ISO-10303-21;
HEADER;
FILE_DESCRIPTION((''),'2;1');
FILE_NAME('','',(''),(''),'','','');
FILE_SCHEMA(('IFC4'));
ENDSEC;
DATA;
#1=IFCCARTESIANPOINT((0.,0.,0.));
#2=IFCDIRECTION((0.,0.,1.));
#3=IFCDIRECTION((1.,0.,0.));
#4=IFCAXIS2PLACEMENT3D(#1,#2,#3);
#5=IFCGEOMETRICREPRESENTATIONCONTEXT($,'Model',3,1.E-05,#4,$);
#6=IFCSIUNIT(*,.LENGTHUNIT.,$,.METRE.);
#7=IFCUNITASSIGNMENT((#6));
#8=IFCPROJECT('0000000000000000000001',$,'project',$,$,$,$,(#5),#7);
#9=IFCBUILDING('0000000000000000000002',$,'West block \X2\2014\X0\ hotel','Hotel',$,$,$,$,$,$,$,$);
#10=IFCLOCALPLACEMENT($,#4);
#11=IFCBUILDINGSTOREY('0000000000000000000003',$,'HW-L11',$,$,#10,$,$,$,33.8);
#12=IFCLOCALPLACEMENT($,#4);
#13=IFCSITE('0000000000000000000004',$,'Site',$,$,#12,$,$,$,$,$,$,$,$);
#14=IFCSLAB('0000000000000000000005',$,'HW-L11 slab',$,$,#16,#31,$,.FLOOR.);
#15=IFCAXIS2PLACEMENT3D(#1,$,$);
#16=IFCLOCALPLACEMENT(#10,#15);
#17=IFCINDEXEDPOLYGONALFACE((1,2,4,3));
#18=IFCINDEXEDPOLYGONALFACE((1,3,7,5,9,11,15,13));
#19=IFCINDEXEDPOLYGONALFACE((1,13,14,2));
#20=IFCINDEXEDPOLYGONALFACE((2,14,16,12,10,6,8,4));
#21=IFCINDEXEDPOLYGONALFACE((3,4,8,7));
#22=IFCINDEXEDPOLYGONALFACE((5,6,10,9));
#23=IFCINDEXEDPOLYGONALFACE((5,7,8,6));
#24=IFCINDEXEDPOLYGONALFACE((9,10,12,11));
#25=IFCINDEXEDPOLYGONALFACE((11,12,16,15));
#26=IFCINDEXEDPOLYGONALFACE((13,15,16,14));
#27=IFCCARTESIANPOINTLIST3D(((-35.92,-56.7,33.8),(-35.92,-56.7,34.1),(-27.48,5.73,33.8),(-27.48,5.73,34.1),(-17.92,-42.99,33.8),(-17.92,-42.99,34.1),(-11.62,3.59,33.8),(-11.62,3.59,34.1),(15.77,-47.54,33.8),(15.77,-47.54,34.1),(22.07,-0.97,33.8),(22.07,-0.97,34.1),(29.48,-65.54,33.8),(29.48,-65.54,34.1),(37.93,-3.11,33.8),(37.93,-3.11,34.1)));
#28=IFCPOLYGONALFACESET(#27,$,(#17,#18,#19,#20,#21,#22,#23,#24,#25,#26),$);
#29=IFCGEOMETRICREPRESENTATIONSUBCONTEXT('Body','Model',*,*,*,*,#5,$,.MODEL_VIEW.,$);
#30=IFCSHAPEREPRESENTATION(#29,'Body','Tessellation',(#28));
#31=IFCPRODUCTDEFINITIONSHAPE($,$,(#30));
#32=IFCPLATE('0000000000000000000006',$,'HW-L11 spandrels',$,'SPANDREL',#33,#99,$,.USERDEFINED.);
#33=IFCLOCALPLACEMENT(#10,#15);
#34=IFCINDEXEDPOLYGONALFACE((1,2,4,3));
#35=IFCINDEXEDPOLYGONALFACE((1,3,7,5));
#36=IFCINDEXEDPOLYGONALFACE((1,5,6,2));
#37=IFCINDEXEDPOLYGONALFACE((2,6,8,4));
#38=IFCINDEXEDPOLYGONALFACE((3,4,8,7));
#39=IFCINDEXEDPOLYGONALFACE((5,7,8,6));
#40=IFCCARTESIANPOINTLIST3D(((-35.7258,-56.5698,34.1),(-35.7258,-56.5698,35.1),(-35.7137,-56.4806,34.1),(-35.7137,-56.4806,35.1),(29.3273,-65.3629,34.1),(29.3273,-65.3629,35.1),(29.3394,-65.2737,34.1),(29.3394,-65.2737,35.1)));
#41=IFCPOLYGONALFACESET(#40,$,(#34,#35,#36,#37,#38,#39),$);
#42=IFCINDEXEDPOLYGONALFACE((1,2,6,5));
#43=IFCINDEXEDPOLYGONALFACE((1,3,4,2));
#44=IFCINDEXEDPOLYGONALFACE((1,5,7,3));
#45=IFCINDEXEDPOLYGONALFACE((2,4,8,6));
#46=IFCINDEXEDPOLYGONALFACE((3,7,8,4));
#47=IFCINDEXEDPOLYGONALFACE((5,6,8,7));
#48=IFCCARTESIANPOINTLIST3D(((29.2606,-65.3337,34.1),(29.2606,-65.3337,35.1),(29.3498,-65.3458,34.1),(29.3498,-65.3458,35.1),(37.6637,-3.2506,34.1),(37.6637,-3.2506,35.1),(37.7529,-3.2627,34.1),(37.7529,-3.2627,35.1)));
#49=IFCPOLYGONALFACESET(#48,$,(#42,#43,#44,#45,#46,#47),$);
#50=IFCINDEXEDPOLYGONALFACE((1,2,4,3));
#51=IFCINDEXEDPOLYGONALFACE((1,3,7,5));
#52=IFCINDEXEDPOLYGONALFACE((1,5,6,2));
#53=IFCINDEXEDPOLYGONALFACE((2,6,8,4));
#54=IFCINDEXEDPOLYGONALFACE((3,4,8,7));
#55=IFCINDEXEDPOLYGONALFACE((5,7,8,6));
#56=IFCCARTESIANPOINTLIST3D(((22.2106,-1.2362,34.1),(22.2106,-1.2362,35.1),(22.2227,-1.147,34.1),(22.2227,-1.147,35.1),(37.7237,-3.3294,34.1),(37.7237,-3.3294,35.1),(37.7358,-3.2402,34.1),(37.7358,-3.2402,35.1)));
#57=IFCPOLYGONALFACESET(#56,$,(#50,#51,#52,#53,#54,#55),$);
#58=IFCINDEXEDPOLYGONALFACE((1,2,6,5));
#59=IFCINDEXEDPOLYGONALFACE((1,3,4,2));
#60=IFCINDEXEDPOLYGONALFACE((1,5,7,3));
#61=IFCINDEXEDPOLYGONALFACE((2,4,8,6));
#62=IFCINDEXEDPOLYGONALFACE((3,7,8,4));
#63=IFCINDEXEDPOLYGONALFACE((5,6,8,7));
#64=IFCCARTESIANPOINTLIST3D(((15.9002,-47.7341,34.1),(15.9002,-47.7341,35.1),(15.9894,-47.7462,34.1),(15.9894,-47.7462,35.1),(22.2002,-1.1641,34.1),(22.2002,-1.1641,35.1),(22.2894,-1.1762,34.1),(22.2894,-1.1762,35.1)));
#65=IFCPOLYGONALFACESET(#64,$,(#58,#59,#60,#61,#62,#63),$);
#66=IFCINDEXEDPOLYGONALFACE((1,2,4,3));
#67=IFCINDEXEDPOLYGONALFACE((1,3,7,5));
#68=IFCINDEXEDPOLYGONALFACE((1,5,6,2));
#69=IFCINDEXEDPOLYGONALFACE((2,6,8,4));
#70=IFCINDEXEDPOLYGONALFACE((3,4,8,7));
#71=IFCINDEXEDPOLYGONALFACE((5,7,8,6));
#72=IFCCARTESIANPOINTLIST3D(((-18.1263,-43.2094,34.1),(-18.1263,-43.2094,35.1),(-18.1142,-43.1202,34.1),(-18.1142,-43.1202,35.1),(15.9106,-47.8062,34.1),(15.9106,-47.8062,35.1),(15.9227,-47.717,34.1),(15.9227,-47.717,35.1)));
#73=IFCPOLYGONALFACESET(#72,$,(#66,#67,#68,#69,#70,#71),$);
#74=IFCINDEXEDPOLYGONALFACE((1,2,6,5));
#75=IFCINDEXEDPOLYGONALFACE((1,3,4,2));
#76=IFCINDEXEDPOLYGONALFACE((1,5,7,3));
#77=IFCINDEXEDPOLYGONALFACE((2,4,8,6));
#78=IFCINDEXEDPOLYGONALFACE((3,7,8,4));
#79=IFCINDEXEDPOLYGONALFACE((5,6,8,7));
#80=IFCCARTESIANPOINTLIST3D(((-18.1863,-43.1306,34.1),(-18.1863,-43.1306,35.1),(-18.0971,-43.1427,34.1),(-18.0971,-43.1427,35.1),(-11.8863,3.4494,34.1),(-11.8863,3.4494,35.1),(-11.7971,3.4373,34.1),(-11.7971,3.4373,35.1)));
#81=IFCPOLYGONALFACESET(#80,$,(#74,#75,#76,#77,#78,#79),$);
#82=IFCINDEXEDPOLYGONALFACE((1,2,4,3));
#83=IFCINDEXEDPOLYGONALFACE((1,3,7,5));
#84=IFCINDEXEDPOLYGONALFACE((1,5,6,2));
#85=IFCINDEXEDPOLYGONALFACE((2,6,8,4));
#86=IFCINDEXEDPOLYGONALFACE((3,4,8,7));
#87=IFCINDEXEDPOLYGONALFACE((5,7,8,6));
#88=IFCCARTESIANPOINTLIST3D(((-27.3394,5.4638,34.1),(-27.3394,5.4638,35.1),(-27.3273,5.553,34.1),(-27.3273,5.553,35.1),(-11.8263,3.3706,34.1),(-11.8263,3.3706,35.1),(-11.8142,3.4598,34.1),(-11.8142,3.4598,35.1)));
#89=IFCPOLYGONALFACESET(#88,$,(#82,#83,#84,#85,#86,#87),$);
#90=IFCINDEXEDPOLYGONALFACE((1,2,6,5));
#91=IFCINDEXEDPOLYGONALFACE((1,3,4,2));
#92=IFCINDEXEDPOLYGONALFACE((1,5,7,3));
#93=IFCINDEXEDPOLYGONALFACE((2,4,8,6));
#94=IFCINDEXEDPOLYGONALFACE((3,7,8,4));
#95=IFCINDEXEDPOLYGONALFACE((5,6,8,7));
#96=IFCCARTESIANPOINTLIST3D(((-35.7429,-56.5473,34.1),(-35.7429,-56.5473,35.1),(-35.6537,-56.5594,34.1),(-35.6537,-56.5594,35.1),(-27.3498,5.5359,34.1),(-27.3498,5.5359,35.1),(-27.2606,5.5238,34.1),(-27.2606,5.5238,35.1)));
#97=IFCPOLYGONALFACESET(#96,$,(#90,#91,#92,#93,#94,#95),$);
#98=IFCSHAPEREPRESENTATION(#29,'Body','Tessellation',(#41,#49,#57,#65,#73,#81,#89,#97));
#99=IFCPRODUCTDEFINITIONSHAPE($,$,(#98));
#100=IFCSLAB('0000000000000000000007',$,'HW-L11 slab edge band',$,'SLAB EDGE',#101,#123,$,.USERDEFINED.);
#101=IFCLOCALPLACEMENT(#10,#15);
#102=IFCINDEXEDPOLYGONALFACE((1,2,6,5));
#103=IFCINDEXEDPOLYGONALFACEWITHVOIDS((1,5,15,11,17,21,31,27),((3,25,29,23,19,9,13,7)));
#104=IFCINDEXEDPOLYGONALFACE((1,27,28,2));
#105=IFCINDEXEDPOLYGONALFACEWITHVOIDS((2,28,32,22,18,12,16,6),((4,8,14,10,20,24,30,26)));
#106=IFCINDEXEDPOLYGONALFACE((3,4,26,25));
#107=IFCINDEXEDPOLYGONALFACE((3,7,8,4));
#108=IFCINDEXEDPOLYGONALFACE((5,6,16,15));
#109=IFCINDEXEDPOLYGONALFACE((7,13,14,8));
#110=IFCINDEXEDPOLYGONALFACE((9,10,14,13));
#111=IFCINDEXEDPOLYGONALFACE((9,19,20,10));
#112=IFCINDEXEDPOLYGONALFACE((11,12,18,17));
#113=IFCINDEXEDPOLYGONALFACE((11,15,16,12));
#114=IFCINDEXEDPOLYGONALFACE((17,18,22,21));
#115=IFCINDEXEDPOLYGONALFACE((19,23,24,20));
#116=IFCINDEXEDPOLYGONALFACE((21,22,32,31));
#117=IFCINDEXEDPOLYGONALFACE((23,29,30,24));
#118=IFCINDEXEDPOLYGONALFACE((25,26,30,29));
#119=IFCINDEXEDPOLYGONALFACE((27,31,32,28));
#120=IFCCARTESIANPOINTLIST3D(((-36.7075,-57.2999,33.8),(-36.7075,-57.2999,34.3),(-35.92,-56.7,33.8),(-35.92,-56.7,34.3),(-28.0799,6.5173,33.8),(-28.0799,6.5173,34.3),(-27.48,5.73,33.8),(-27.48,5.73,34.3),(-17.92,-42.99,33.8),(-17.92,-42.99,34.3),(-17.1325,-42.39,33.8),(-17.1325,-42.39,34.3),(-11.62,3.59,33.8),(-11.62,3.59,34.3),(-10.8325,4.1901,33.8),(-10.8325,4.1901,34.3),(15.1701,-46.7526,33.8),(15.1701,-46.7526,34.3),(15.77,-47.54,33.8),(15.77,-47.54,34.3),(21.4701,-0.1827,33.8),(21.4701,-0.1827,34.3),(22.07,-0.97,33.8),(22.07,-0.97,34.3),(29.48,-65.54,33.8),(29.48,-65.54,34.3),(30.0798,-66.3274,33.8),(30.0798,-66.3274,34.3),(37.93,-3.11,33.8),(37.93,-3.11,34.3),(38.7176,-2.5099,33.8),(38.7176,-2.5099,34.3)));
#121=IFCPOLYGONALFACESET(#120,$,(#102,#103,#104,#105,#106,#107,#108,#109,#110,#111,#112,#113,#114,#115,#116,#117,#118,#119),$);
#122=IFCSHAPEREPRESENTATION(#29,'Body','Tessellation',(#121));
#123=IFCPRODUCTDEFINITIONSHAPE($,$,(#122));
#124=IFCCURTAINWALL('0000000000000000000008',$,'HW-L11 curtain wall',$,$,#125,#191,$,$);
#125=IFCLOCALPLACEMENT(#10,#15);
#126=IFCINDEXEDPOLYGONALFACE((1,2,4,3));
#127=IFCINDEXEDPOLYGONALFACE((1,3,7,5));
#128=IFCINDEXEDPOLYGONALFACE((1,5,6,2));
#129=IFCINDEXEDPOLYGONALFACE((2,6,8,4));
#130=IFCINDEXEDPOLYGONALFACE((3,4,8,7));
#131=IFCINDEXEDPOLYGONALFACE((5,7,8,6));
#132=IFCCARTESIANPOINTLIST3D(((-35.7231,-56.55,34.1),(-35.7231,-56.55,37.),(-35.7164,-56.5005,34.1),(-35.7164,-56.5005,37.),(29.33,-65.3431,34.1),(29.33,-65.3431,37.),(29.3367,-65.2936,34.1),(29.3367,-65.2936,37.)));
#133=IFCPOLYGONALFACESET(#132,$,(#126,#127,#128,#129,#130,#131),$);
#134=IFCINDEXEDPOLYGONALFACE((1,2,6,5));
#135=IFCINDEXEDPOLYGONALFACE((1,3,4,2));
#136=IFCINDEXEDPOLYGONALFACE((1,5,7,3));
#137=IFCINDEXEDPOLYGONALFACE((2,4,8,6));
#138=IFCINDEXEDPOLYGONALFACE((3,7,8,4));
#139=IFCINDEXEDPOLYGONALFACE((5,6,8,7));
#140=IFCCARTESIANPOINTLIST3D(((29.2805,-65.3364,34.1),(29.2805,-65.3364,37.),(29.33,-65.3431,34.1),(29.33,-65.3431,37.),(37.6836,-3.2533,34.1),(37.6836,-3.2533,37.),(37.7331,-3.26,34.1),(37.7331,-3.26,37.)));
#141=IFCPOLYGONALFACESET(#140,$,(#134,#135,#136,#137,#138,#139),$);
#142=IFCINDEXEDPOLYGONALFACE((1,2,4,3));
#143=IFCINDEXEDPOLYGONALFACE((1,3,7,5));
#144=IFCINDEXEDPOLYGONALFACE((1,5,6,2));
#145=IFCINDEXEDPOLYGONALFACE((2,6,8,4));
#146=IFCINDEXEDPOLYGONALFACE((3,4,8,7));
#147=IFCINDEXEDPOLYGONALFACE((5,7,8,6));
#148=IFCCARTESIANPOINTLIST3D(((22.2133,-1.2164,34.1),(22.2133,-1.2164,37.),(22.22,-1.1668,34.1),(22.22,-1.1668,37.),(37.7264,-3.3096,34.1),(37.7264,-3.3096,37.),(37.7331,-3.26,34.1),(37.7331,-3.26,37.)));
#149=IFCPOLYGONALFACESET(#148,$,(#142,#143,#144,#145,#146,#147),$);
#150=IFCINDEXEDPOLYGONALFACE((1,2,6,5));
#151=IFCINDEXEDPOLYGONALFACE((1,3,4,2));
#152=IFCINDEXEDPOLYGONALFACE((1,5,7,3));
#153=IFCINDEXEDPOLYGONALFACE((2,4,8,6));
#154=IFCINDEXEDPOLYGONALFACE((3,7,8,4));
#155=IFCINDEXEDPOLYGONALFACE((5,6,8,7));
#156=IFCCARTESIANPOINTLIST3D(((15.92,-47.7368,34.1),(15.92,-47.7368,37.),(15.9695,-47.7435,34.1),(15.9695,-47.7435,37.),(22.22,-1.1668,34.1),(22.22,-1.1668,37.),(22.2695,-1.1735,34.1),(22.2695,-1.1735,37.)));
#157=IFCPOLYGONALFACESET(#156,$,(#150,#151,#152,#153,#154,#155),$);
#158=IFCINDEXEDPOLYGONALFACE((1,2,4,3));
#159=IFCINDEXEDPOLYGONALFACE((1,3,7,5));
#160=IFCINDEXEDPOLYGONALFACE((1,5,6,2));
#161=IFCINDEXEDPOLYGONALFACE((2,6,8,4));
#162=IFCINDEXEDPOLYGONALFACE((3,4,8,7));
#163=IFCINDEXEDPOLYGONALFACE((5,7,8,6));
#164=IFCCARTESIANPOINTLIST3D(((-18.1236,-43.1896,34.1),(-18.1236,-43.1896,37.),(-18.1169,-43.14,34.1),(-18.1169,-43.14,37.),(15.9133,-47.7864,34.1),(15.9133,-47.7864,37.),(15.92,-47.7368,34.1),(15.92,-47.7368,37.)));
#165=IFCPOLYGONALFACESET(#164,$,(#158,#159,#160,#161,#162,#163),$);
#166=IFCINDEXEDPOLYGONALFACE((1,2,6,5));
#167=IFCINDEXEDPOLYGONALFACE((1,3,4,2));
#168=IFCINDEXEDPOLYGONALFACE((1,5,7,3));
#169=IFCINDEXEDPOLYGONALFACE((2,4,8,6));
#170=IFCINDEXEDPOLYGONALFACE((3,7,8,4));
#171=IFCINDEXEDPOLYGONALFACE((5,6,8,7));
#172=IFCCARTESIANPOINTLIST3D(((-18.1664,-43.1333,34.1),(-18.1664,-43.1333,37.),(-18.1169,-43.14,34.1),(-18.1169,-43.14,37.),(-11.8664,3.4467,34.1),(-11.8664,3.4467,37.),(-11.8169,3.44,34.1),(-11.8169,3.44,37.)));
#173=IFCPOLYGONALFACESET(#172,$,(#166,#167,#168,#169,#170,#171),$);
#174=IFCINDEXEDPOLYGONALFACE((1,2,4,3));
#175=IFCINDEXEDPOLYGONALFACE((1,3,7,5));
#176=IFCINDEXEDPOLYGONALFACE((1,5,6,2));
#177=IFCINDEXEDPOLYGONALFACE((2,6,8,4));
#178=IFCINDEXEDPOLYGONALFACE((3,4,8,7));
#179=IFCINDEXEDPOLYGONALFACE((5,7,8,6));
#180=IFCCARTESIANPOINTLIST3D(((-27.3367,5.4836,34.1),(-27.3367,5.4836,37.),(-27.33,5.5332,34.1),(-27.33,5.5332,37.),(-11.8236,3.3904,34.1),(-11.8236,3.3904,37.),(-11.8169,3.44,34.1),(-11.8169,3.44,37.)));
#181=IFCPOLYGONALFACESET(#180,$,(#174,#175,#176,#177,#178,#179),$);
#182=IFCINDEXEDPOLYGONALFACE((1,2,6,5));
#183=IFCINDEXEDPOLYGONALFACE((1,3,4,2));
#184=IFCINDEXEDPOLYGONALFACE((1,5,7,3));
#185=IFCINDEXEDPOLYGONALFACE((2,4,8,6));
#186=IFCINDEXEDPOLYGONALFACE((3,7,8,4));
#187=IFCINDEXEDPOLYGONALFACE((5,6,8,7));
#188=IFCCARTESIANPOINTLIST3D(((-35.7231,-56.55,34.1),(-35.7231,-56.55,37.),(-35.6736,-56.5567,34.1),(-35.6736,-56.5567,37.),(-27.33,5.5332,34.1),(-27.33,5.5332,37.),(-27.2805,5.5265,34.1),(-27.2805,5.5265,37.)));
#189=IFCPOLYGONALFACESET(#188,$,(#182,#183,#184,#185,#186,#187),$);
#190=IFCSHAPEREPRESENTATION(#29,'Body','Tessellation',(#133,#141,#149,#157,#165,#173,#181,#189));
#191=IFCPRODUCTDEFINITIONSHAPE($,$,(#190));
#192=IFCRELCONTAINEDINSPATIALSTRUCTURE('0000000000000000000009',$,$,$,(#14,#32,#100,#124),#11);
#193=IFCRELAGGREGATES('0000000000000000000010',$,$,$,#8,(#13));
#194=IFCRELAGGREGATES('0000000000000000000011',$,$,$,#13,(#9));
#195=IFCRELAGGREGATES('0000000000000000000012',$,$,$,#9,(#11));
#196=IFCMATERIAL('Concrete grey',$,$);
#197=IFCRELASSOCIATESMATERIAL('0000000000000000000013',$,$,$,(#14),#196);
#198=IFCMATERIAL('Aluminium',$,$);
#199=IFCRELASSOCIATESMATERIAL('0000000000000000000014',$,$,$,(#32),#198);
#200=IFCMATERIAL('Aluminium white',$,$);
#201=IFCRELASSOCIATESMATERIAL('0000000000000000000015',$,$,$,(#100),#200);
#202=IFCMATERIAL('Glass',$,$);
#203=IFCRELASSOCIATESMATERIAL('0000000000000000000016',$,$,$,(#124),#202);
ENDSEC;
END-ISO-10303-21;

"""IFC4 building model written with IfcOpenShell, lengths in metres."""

from ifc_helpers import new_model, si_unit, frame, origin_with_axes, place, context, subcontext, project, spatial, polyline, outline, extrude, material, element, save


model = new_model("IFC4")

# Units and contexts
model_context = context("Model", 3, precision=1e-05, world=origin_with_axes())
body_context = subcontext(model_context, "Body", "Model", "MODEL_VIEW")
ifc_project = project(units=[si_unit("LENGTHUNIT", "METRE")], contexts=[model_context])

# Site, building, storey
site_placement = place(None, origin_with_axes())
site = spatial("IfcSite", under=ifc_project, at=site_placement, Name="Site")
building = spatial("IfcBuilding", under=site, Name="West block — hotel", Description="Hotel")
storey_placement = place(None, origin_with_axes())
storey = spatial("IfcBuildingStorey", under=building, at=storey_placement, Name="HW-L11", Elevation=33.8)

# Shared definitions
ifc_material_1 = material(Name="Aluminium")

# Slab
ifc_material_2 = material(Name="Concrete grey")
slab_1_placement = place(storey_placement, origin_with_axes())
element("IfcSlab", 1, at=slab_1_placement, inside=storey, material=ifc_material_2, Name="HW-L11 slab", PredefinedType="FLOOR", context=body_context, shape_type="SweptSolid", body=[
    extrude(outline(polyline([(-35.92, -56.7), (29.48, -65.54), (37.93, -3.11), (22.07, -0.97), (15.77, -47.54), (-17.92, -42.99), (-11.62, 3.59), (-27.48, 5.73), (-35.92, -56.7)])), frame((0.0, 0.0, 33.8), z_axis=(0.0, 0.0, 1.0), x_axis=(1.0, 0.0, 0.0)), (0.0, 0.0, 1.0), 0.3),
])

# Plate
plate_placement = place(storey_placement, origin_with_axes())
element("IfcPlate", 2, at=plate_placement, inside=storey, material=ifc_material_1, Name="HW-L11 spandrels", ObjectType="SPANDREL", PredefinedType="USERDEFINED", context=body_context, shape_type="SweptSolid", body=[
    extrude(outline(polyline([(-35.7258, -56.5698), (29.3273, -65.3629), (29.3394, -65.2737), (-35.7137, -56.4806), (-35.7258, -56.5698)])), frame((0.0, 0.0, 34.1), z_axis=(0.0, 0.0, 1.0), x_axis=(1.0, 0.0, 0.0)), (0.0, 0.0, 1.0), 1.0),
    extrude(outline(polyline([(29.3498, -65.3458), (37.7529, -3.2627), (37.6637, -3.2506), (29.2606, -65.3337), (29.3498, -65.3458)])), frame((0.0, 0.0, 34.1), z_axis=(0.0, 0.0, 1.0), x_axis=(1.0, 0.0, 0.0)), (0.0, 0.0, 1.0), 1.0),
    extrude(outline(polyline([(37.7358, -3.2402), (22.2227, -1.147), (22.2106, -1.2362), (37.7237, -3.3294), (37.7358, -3.2402)])), frame((0.0, 0.0, 34.1), z_axis=(0.0, 0.0, 1.0), x_axis=(1.0, 0.0, 0.0)), (0.0, 0.0, 1.0), 1.0),
    extrude(outline(polyline([(22.2002, -1.1641), (15.9002, -47.7341), (15.9894, -47.7462), (22.2894, -1.1762), (22.2002, -1.1641)])), frame((0.0, 0.0, 34.1), z_axis=(0.0, 0.0, 1.0), x_axis=(1.0, 0.0, 0.0)), (0.0, 0.0, 1.0), 1.0),
    extrude(outline(polyline([(15.9227, -47.717), (-18.1142, -43.1202), (-18.1263, -43.2094), (15.9106, -47.8062), (15.9227, -47.717)])), frame((0.0, 0.0, 34.1), z_axis=(0.0, 0.0, 1.0), x_axis=(1.0, 0.0, 0.0)), (0.0, 0.0, 1.0), 1.0),
    extrude(outline(polyline([(-18.0971, -43.1427), (-11.7971, 3.4373), (-11.8863, 3.4494), (-18.1863, -43.1306), (-18.0971, -43.1427)])), frame((0.0, 0.0, 34.1), z_axis=(0.0, 0.0, 1.0), x_axis=(1.0, 0.0, 0.0)), (0.0, 0.0, 1.0), 1.0),
    extrude(outline(polyline([(-11.8142, 3.4598), (-27.3273, 5.553), (-27.3394, 5.4638), (-11.8263, 3.3706), (-11.8142, 3.4598)])), frame((0.0, 0.0, 34.1), z_axis=(0.0, 0.0, 1.0), x_axis=(1.0, 0.0, 0.0)), (0.0, 0.0, 1.0), 1.0),
    extrude(outline(polyline([(-27.3498, 5.5359), (-35.7429, -56.5473), (-35.6537, -56.5594), (-27.2606, 5.5238), (-27.3498, 5.5359)])), frame((0.0, 0.0, 34.1), z_axis=(0.0, 0.0, 1.0), x_axis=(1.0, 0.0, 0.0)), (0.0, 0.0, 1.0), 1.0),
])

# Slab
ifc_material_3 = material(Name="Aluminium white")
slab_2_placement = place(storey_placement, origin_with_axes())
element("IfcSlab", 3, at=slab_2_placement, inside=storey, material=ifc_material_3, Name="HW-L11 slab edge band", ObjectType="SLAB EDGE", PredefinedType="USERDEFINED", context=body_context, shape_type="SweptSolid", body=[
    extrude(outline(polyline([(-36.7075, -57.2999), (30.0798, -66.3274), (38.7176, -2.5099), (21.4701, -0.1827), (15.1701, -46.7526), (-17.1325, -42.39), (-10.8325, 4.1901), (-28.0799, 6.5173), (-36.7075, -57.2999)]), holes=[polyline([(-35.92, -56.7), (29.48, -65.54), (37.93, -3.11), (22.07, -0.97), (15.77, -47.54), (-17.92, -42.99), (-11.62, 3.59), (-27.48, 5.73), (-35.92, -56.7)])]), frame((0.0, 0.0, 33.8), z_axis=(0.0, 0.0, 1.0), x_axis=(1.0, 0.0, 0.0)), (0.0, 0.0, 1.0), 0.5),
])

# Curtain wall
ifc_material_4 = material(Name="Glass")
curtain_wall_placement = place(storey_placement, origin_with_axes())
element("IfcCurtainWall", 4, at=curtain_wall_placement, inside=storey, material=ifc_material_4, Name="HW-L11 curtain wall", context=body_context, shape_type="SweptSolid", body=[
    extrude(outline(polyline([(-35.7231, -56.55), (29.33, -65.3431), (29.3367, -65.2936), (-35.7164, -56.5005), (-35.7231, -56.55)])), frame((0.0, 0.0, 34.1), z_axis=(0.0, 0.0, 1.0), x_axis=(1.0, 0.0, 0.0)), (0.0, 0.0, 1.0), 2.9),
    extrude(outline(polyline([(29.33, -65.3431), (37.7331, -3.26), (37.6836, -3.2533), (29.2805, -65.3364), (29.33, -65.3431)])), frame((0.0, 0.0, 34.1), z_axis=(0.0, 0.0, 1.0), x_axis=(1.0, 0.0, 0.0)), (0.0, 0.0, 1.0), 2.9),
    extrude(outline(polyline([(37.7331, -3.26), (22.22, -1.1668), (22.2133, -1.2164), (37.7264, -3.3096), (37.7331, -3.26)])), frame((0.0, 0.0, 34.1), z_axis=(0.0, 0.0, 1.0), x_axis=(1.0, 0.0, 0.0)), (0.0, 0.0, 1.0), 2.9),
    extrude(outline(polyline([(22.22, -1.1668), (15.92, -47.7368), (15.9695, -47.7435), (22.2695, -1.1735), (22.22, -1.1668)])), frame((0.0, 0.0, 34.1), z_axis=(0.0, 0.0, 1.0), x_axis=(1.0, 0.0, 0.0)), (0.0, 0.0, 1.0), 2.9),
    extrude(outline(polyline([(15.92, -47.7368), (-18.1169, -43.14), (-18.1236, -43.1896), (15.9133, -47.7864), (15.92, -47.7368)])), frame((0.0, 0.0, 34.1), z_axis=(0.0, 0.0, 1.0), x_axis=(1.0, 0.0, 0.0)), (0.0, 0.0, 1.0), 2.9),
    extrude(outline(polyline([(-18.1169, -43.14), (-11.8169, 3.44), (-11.8664, 3.4467), (-18.1664, -43.1333), (-18.1169, -43.14)])), frame((0.0, 0.0, 34.1), z_axis=(0.0, 0.0, 1.0), x_axis=(1.0, 0.0, 0.0)), (0.0, 0.0, 1.0), 2.9),
    extrude(outline(polyline([(-11.8169, 3.44), (-27.33, 5.5332), (-27.3367, 5.4836), (-11.8236, 3.3904), (-11.8169, 3.44)])), frame((0.0, 0.0, 34.1), z_axis=(0.0, 0.0, 1.0), x_axis=(1.0, 0.0, 0.0)), (0.0, 0.0, 1.0), 2.9),
    extrude(outline(polyline([(-27.33, 5.5332), (-35.7231, -56.55), (-35.6736, -56.5567), (-27.2805, 5.5265), (-27.33, 5.5332)])), frame((0.0, 0.0, 34.1), z_axis=(0.0, 0.0, 1.0), x_axis=(1.0, 0.0, 0.0)), (0.0, 0.0, 1.0), 2.9),
])

save(model, "model.ifc")
